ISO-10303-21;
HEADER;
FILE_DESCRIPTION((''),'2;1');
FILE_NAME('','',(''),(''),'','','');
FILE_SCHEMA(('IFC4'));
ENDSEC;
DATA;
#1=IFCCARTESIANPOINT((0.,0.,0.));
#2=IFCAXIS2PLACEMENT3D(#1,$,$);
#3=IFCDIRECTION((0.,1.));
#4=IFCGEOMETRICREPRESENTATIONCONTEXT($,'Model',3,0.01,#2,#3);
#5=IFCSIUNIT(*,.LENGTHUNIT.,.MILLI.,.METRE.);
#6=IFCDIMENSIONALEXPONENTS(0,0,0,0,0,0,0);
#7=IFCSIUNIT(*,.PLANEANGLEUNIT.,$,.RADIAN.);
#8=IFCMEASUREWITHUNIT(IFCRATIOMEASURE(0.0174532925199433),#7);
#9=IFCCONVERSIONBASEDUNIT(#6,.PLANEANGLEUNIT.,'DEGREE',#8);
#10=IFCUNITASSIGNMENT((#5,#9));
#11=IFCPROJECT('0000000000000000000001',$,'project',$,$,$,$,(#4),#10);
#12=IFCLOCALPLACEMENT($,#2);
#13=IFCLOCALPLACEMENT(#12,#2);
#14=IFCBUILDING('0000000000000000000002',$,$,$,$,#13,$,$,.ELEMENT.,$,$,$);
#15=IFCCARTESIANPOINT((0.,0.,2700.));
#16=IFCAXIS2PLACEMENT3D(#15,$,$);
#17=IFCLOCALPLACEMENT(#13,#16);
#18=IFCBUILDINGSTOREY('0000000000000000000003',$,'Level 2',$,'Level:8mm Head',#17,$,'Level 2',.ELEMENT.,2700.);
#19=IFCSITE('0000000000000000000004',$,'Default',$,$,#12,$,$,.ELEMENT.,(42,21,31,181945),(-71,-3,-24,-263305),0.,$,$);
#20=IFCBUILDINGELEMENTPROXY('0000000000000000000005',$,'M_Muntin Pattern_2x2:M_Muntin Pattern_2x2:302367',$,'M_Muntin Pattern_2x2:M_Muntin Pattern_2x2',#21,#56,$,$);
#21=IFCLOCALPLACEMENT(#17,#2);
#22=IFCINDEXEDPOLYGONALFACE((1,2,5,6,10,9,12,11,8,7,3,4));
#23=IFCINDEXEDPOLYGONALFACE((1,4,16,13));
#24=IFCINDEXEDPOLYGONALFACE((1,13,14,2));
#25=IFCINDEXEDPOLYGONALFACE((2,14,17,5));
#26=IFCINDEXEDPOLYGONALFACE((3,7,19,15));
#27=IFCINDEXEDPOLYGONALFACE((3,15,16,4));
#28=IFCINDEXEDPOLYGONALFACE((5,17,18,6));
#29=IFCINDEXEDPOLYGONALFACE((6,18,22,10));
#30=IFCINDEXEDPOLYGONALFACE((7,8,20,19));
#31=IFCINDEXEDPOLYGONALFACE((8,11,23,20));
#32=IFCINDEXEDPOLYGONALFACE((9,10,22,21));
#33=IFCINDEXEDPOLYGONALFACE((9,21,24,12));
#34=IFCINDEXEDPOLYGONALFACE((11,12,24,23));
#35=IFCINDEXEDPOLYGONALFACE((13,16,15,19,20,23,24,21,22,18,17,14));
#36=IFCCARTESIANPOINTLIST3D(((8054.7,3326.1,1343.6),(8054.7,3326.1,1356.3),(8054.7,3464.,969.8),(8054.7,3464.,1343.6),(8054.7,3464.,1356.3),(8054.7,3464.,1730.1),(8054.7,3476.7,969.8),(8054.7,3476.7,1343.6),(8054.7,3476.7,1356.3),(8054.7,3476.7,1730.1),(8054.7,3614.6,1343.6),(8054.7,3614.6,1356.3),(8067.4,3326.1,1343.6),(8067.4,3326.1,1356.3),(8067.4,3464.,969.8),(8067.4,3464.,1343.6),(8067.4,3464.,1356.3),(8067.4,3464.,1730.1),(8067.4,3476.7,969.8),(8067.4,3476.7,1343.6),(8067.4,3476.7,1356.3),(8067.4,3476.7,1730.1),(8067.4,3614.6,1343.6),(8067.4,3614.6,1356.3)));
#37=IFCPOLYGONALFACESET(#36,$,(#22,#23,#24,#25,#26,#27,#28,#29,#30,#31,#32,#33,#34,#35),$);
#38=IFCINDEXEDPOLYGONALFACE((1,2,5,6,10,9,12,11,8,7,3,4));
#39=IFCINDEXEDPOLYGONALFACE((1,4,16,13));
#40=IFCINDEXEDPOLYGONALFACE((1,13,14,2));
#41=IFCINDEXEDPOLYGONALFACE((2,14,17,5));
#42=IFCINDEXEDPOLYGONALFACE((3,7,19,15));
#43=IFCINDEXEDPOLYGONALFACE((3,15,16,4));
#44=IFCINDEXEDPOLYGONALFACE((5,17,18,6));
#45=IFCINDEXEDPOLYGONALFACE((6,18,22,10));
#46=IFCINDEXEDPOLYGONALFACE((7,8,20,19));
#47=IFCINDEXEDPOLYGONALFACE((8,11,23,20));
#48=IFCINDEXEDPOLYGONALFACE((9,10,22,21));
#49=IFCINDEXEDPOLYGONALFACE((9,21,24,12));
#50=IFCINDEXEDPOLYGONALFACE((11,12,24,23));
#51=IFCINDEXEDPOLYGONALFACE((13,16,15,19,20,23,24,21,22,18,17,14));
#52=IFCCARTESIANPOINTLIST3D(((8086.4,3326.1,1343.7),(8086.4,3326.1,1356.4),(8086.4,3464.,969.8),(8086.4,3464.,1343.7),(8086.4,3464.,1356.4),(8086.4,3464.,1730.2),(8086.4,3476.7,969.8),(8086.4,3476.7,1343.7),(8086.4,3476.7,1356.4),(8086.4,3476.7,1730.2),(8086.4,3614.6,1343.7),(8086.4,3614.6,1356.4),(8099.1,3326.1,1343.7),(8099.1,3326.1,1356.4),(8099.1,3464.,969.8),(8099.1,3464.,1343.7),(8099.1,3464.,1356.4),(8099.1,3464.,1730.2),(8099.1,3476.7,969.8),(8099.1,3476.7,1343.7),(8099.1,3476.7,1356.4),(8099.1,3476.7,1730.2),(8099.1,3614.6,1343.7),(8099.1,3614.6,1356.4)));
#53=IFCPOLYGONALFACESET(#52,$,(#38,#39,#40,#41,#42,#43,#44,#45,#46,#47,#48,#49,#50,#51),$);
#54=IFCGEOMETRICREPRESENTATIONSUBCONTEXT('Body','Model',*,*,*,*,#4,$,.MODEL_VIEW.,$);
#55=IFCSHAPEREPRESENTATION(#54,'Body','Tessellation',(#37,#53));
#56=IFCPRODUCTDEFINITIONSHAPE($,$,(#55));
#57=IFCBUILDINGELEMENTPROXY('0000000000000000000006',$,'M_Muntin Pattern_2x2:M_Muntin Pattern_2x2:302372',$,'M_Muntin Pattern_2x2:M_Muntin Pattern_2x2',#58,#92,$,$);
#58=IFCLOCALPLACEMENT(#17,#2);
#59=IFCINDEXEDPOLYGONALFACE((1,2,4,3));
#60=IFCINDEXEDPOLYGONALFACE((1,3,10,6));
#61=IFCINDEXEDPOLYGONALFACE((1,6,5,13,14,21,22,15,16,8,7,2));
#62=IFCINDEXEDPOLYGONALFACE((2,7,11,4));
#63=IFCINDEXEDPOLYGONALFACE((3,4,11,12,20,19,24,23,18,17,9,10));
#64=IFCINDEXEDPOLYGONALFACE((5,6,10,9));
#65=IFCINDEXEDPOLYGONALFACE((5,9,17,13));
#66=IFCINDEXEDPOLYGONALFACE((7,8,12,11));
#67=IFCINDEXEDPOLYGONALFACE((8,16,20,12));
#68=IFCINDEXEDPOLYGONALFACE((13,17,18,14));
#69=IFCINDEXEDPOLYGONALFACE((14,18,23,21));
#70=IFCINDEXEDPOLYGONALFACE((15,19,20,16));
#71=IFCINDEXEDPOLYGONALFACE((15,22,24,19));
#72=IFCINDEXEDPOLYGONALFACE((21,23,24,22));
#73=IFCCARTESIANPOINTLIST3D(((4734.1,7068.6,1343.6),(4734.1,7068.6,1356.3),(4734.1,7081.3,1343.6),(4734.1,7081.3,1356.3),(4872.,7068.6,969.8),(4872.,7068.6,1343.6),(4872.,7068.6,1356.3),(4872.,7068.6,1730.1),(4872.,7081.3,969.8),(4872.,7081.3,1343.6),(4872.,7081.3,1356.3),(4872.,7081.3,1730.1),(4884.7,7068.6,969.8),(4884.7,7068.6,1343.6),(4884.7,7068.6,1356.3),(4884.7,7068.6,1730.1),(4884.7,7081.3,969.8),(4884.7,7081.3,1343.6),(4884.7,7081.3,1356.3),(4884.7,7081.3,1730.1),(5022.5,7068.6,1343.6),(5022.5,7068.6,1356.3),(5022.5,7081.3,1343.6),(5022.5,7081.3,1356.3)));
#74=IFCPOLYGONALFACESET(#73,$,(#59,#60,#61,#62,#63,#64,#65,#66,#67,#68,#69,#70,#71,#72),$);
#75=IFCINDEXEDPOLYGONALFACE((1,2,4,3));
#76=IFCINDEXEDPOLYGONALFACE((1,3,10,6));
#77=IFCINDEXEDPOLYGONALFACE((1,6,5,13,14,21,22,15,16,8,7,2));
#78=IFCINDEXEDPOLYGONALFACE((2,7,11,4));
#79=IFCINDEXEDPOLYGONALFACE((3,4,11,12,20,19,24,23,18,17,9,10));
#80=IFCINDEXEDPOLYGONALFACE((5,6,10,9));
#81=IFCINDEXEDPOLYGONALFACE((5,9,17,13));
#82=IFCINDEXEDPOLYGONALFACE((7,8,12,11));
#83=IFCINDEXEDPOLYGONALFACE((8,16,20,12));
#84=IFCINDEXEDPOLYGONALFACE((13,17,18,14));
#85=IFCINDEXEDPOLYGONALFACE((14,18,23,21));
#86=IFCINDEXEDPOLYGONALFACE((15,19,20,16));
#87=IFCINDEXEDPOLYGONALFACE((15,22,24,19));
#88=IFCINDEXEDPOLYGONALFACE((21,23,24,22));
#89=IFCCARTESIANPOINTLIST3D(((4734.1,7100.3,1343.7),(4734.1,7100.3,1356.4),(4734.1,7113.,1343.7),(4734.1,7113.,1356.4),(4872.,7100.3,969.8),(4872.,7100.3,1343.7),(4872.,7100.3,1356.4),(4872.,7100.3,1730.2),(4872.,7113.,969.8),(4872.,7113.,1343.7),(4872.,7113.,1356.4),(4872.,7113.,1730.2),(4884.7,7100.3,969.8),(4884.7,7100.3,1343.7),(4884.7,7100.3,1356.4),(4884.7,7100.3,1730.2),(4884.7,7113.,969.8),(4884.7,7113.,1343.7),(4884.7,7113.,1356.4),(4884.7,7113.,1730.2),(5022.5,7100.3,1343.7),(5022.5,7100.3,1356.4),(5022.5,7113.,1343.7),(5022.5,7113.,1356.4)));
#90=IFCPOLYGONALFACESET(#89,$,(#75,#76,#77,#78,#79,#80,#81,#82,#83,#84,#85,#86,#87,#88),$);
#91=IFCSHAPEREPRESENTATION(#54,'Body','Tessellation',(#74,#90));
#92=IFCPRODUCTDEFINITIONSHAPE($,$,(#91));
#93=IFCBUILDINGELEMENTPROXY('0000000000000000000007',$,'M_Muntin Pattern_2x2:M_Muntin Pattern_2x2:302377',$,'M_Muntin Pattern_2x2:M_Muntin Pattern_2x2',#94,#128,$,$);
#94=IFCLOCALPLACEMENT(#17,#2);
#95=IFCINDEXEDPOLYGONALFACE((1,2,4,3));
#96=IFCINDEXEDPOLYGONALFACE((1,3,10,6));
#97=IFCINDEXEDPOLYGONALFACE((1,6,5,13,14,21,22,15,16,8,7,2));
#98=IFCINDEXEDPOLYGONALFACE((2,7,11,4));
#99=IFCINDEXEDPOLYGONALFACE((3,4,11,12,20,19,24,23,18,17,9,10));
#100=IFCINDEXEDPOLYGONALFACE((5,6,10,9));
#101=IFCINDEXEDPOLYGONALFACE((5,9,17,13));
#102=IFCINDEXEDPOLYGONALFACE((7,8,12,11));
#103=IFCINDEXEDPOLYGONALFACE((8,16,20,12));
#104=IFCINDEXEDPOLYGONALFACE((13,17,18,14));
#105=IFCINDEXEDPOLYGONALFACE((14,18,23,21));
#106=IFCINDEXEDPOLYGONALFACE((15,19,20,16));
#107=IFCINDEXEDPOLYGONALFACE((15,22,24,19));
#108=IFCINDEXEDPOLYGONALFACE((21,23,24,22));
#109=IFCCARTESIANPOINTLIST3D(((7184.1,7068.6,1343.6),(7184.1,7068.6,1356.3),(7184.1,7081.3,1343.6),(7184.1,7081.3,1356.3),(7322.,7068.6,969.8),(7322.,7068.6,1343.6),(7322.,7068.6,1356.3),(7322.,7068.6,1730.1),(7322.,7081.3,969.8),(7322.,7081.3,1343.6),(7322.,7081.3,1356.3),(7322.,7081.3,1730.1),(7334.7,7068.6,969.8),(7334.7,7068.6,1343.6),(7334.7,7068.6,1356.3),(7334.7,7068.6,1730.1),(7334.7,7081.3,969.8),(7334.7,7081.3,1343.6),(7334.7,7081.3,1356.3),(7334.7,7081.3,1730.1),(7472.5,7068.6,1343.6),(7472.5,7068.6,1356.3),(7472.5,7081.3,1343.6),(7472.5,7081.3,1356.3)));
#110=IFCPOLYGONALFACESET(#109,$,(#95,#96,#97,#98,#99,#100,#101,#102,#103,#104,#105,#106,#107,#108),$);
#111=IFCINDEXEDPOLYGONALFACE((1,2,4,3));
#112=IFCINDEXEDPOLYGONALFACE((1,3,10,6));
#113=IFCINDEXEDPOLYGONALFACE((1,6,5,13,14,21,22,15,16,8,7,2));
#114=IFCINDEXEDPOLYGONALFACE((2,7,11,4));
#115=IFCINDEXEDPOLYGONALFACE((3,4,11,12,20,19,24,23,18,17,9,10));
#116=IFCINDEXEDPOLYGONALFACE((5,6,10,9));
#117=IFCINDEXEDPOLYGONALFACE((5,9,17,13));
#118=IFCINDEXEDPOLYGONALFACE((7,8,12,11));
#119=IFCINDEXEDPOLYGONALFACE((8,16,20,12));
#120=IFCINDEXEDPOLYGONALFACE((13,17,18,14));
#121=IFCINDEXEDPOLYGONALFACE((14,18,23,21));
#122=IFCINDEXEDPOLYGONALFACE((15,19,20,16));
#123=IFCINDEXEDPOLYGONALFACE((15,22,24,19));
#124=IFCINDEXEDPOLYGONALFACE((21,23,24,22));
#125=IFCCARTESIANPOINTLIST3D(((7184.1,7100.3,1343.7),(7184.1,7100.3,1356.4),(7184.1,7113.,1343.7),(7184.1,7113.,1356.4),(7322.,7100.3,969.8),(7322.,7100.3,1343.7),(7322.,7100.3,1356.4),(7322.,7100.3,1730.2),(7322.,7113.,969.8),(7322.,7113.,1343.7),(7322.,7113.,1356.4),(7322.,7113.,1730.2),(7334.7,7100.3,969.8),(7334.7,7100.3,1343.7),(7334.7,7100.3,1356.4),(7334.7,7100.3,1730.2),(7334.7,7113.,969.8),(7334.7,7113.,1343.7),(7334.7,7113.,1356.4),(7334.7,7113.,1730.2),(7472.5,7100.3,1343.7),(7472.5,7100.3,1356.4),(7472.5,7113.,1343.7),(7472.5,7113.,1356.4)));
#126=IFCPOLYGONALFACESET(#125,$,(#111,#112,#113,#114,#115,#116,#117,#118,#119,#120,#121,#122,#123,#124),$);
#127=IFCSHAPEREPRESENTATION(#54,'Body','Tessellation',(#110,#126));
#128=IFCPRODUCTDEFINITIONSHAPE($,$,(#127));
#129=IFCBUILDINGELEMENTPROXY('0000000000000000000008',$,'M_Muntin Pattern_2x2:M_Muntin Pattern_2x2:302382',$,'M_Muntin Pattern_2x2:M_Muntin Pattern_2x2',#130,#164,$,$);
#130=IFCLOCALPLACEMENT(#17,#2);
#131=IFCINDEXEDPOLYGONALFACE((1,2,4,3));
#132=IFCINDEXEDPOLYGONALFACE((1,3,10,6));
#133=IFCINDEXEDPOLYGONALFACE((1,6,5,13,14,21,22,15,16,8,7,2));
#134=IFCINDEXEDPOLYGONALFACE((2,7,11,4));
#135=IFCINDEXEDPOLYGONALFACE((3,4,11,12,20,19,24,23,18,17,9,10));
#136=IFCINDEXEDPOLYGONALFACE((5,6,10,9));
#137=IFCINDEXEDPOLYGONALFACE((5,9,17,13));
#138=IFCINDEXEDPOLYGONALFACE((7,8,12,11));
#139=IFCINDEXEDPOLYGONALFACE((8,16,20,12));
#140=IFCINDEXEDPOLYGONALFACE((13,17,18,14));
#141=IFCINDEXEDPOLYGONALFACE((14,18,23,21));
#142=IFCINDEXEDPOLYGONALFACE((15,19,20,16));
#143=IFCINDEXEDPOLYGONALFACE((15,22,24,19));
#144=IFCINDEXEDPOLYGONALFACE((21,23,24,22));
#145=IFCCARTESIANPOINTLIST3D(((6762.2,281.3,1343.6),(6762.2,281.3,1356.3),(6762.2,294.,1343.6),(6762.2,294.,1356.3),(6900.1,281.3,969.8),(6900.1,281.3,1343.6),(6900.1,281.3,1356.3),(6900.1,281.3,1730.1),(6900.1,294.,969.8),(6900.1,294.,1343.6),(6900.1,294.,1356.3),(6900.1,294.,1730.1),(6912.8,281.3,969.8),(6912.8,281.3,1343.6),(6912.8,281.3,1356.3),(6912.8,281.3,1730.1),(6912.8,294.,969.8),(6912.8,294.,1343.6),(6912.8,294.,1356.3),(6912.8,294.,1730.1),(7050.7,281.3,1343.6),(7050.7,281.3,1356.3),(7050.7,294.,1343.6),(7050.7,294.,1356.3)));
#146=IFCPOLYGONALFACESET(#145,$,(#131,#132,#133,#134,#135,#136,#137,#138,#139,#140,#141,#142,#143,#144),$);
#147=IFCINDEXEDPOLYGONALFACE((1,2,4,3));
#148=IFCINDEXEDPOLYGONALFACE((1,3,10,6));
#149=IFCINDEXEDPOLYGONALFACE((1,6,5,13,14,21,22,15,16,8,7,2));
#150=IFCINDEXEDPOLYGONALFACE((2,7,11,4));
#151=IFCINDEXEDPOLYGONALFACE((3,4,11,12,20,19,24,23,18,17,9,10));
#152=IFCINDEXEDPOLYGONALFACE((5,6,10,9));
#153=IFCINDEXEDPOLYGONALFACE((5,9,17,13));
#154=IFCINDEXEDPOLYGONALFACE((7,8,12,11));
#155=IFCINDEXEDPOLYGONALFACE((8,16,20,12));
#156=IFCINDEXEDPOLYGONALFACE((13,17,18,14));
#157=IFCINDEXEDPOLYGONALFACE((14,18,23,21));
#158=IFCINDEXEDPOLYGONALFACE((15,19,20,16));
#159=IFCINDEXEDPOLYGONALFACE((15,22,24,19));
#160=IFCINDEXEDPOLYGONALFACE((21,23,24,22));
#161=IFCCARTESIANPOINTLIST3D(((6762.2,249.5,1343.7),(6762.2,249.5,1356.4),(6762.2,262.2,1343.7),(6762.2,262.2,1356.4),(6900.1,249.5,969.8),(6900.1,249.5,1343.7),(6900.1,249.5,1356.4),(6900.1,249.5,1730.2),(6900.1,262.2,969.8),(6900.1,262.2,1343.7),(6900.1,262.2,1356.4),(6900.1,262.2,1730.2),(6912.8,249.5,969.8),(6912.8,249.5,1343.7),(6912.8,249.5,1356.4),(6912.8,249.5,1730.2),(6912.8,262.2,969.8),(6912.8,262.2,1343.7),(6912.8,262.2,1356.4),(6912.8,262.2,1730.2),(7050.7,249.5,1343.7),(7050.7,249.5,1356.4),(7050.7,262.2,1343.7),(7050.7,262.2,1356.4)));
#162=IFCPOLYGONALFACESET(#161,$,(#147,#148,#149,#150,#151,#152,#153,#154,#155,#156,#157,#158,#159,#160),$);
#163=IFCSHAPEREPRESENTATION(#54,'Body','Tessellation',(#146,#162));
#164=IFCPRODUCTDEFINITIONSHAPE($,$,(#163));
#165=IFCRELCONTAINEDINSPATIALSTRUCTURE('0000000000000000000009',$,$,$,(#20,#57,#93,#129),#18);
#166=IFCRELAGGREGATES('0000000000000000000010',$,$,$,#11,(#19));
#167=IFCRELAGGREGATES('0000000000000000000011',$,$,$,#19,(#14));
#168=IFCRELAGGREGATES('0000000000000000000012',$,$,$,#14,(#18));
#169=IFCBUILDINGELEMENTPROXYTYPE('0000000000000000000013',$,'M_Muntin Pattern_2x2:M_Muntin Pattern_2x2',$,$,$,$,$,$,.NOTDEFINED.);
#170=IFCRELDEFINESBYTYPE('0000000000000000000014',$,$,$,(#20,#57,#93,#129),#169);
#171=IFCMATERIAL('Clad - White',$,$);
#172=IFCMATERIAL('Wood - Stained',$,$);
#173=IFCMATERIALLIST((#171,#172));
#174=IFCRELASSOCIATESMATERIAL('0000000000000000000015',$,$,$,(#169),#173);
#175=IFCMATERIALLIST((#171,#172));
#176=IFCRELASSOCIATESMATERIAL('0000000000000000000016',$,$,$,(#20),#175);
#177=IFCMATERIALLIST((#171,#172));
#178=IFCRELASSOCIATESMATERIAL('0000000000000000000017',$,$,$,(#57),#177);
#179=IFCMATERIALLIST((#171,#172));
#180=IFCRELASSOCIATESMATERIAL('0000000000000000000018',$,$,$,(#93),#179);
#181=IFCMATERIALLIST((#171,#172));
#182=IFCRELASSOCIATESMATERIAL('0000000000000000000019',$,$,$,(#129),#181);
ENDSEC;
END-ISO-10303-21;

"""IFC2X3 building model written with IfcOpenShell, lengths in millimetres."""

from ifc_helpers import new_model, entity, si_unit, converted_unit, direction, frame, origin, place, context, subcontext, project, spatial, polyline, outline, extrude, source, transform, mapped, material, material_list, type_object, type_shapes, element, save


model = new_model("IFC2X3")

# Units and contexts
model_context = context("Model", 3, precision=0.01, world=origin(), true_north=direction((0.0, 1.0)))
body_context = subcontext(model_context, "Body", "Model", "MODEL_VIEW")
ifc_project = project(units=[si_unit("LENGTHUNIT", "METRE", prefix="MILLI"), converted_unit("PLANEANGLEUNIT", "DEGREE", entity("IfcRatioMeasure", 0.0174532925199433), si_unit("PLANEANGLEUNIT", "RADIAN"), dimensions=[0, 0, 0, 0, 0, 0, 0])], contexts=[model_context])

# Site, building, storey
site_placement = place(None, origin())
site = spatial("IfcSite", under=ifc_project, at=site_placement, Name="Default", CompositionType="ELEMENT", RefLatitude=(42, 21, 31, 181945), RefLongitude=(-71, -3, -24, -263305), RefElevation=0.0)
building_placement = place(site_placement, origin())
building = spatial("IfcBuilding", under=site, at=building_placement, CompositionType="ELEMENT")
storey_placement = place(building_placement, frame((0.0, 0.0, 2700.0)))
storey = spatial("IfcBuildingStorey", under=building, at=storey_placement, Name="Level 2", ObjectType="Level:8mm Head", LongName="Level 2", CompositionType="ELEMENT", Elevation=2700.0)

# Building element proxies
ifc_material_1 = material(Name="Clad - White")
ifc_material_2 = material(Name="Wood - Stained")
ifc_material_list_1 = material_list([ifc_material_1, ifc_material_2])
ifc_material_list_2 = material_list([ifc_material_1, ifc_material_2])
building_element_proxy_type_1 = type_object("IfcBuildingElementProxyType", Name="M_Muntin Pattern_2x2:M_Muntin Pattern_2x2", PredefinedType="NOTDEFINED", material=ifc_material_list_2)
shared_shape_1 = source(origin(), body_context, "Body", "SweptSolid", [
    extrude(outline(polyline([(6.4, -6.4), (380.1, -6.4), (380.1, 6.3), (6.4, 6.3), (6.4, 144.2), (-6.3, 144.2), (-6.3, 6.3), (-380.2, 6.3), (-380.2, -6.4), (-6.3, -6.4), (-6.3, -144.2), (6.4, -144.2), (6.4, -6.4)])), frame((0.0, 9.5, 380.1), z_axis=(0.0, 1.0, 0.0), x_axis=(0.0, 0.0, 1.0)), (0.0, 0.0, 1.0), 12.7),
    extrude(outline(polyline([(6.4, -6.4), (380.2, -6.4), (380.2, 6.3), (6.4, 6.3), (6.4, 144.2), (-6.3, 144.2), (-6.3, 6.3), (-380.2, 6.3), (-380.2, -6.4), (-6.3, -6.4), (-6.3, -144.2), (6.4, -144.2), (6.4, -6.4)])), frame((0.0, -22.2, 380.2), z_axis=(0.0, 1.0, 0.0), x_axis=(0.0, 0.0, 1.0)), (0.0, 0.0, 1.0), 12.7),
])
type_shapes(building_element_proxy_type_1, [shared_shape_1])
proxy_1_placement = place(storey_placement, frame((8076.9, 3470.4, 969.8), z_axis=(0.0, 0.0, 1.0), x_axis=(0.0, 1.0, 0.0)))
element("IfcBuildingElementProxy", 1, at=proxy_1_placement, inside=storey, type_object=building_element_proxy_type_1, material=ifc_material_list_1, Name="M_Muntin Pattern_2x2:M_Muntin Pattern_2x2:302367", ObjectType="M_Muntin Pattern_2x2:M_Muntin Pattern_2x2", context=body_context, shape_type="MappedRepresentation", body=[
    mapped(shared_shape_1, transform((0.0, 0.0, 0.0), scale=1.0)),
])
ifc_material_list_3 = material_list([ifc_material_1, ifc_material_2])
proxy_2_placement = place(storey_placement, frame((4878.3, 7090.8, 969.8), z_axis=(0.0, 0.0, 1.0), x_axis=(-1.0, 0.0, 0.0)))
element("IfcBuildingElementProxy", 2, at=proxy_2_placement, inside=storey, type_object=building_element_proxy_type_1, material=ifc_material_list_3, Name="M_Muntin Pattern_2x2:M_Muntin Pattern_2x2:302372", ObjectType="M_Muntin Pattern_2x2:M_Muntin Pattern_2x2", context=body_context, shape_type="MappedRepresentation", body=[
    mapped(shared_shape_1, transform((0.0, 0.0, 0.0), scale=1.0)),
])
ifc_material_list_4 = material_list([ifc_material_1, ifc_material_2])
proxy_3_placement = place(storey_placement, frame((7328.3, 7090.8, 969.8), z_axis=(0.0, 0.0, 1.0), x_axis=(-1.0, 0.0, 0.0)))
element("IfcBuildingElementProxy", 3, at=proxy_3_placement, inside=storey, type_object=building_element_proxy_type_1, material=ifc_material_list_4, Name="M_Muntin Pattern_2x2:M_Muntin Pattern_2x2:302377", ObjectType="M_Muntin Pattern_2x2:M_Muntin Pattern_2x2", context=body_context, shape_type="MappedRepresentation", body=[
    mapped(shared_shape_1, transform((0.0, 0.0, 0.0), scale=1.0)),
])
ifc_material_list_5 = material_list([ifc_material_1, ifc_material_2])
proxy_4_placement = place(storey_placement, frame((6906.5, 271.8, 969.8)))
element("IfcBuildingElementProxy", 4, at=proxy_4_placement, inside=storey, type_object=building_element_proxy_type_1, material=ifc_material_list_5, Name="M_Muntin Pattern_2x2:M_Muntin Pattern_2x2:302382", ObjectType="M_Muntin Pattern_2x2:M_Muntin Pattern_2x2", context=body_context, shape_type="MappedRepresentation", body=[
    mapped(shared_shape_1, transform((0.0, 0.0, 0.0), scale=1.0)),
])

save(model, "model.ifc")
